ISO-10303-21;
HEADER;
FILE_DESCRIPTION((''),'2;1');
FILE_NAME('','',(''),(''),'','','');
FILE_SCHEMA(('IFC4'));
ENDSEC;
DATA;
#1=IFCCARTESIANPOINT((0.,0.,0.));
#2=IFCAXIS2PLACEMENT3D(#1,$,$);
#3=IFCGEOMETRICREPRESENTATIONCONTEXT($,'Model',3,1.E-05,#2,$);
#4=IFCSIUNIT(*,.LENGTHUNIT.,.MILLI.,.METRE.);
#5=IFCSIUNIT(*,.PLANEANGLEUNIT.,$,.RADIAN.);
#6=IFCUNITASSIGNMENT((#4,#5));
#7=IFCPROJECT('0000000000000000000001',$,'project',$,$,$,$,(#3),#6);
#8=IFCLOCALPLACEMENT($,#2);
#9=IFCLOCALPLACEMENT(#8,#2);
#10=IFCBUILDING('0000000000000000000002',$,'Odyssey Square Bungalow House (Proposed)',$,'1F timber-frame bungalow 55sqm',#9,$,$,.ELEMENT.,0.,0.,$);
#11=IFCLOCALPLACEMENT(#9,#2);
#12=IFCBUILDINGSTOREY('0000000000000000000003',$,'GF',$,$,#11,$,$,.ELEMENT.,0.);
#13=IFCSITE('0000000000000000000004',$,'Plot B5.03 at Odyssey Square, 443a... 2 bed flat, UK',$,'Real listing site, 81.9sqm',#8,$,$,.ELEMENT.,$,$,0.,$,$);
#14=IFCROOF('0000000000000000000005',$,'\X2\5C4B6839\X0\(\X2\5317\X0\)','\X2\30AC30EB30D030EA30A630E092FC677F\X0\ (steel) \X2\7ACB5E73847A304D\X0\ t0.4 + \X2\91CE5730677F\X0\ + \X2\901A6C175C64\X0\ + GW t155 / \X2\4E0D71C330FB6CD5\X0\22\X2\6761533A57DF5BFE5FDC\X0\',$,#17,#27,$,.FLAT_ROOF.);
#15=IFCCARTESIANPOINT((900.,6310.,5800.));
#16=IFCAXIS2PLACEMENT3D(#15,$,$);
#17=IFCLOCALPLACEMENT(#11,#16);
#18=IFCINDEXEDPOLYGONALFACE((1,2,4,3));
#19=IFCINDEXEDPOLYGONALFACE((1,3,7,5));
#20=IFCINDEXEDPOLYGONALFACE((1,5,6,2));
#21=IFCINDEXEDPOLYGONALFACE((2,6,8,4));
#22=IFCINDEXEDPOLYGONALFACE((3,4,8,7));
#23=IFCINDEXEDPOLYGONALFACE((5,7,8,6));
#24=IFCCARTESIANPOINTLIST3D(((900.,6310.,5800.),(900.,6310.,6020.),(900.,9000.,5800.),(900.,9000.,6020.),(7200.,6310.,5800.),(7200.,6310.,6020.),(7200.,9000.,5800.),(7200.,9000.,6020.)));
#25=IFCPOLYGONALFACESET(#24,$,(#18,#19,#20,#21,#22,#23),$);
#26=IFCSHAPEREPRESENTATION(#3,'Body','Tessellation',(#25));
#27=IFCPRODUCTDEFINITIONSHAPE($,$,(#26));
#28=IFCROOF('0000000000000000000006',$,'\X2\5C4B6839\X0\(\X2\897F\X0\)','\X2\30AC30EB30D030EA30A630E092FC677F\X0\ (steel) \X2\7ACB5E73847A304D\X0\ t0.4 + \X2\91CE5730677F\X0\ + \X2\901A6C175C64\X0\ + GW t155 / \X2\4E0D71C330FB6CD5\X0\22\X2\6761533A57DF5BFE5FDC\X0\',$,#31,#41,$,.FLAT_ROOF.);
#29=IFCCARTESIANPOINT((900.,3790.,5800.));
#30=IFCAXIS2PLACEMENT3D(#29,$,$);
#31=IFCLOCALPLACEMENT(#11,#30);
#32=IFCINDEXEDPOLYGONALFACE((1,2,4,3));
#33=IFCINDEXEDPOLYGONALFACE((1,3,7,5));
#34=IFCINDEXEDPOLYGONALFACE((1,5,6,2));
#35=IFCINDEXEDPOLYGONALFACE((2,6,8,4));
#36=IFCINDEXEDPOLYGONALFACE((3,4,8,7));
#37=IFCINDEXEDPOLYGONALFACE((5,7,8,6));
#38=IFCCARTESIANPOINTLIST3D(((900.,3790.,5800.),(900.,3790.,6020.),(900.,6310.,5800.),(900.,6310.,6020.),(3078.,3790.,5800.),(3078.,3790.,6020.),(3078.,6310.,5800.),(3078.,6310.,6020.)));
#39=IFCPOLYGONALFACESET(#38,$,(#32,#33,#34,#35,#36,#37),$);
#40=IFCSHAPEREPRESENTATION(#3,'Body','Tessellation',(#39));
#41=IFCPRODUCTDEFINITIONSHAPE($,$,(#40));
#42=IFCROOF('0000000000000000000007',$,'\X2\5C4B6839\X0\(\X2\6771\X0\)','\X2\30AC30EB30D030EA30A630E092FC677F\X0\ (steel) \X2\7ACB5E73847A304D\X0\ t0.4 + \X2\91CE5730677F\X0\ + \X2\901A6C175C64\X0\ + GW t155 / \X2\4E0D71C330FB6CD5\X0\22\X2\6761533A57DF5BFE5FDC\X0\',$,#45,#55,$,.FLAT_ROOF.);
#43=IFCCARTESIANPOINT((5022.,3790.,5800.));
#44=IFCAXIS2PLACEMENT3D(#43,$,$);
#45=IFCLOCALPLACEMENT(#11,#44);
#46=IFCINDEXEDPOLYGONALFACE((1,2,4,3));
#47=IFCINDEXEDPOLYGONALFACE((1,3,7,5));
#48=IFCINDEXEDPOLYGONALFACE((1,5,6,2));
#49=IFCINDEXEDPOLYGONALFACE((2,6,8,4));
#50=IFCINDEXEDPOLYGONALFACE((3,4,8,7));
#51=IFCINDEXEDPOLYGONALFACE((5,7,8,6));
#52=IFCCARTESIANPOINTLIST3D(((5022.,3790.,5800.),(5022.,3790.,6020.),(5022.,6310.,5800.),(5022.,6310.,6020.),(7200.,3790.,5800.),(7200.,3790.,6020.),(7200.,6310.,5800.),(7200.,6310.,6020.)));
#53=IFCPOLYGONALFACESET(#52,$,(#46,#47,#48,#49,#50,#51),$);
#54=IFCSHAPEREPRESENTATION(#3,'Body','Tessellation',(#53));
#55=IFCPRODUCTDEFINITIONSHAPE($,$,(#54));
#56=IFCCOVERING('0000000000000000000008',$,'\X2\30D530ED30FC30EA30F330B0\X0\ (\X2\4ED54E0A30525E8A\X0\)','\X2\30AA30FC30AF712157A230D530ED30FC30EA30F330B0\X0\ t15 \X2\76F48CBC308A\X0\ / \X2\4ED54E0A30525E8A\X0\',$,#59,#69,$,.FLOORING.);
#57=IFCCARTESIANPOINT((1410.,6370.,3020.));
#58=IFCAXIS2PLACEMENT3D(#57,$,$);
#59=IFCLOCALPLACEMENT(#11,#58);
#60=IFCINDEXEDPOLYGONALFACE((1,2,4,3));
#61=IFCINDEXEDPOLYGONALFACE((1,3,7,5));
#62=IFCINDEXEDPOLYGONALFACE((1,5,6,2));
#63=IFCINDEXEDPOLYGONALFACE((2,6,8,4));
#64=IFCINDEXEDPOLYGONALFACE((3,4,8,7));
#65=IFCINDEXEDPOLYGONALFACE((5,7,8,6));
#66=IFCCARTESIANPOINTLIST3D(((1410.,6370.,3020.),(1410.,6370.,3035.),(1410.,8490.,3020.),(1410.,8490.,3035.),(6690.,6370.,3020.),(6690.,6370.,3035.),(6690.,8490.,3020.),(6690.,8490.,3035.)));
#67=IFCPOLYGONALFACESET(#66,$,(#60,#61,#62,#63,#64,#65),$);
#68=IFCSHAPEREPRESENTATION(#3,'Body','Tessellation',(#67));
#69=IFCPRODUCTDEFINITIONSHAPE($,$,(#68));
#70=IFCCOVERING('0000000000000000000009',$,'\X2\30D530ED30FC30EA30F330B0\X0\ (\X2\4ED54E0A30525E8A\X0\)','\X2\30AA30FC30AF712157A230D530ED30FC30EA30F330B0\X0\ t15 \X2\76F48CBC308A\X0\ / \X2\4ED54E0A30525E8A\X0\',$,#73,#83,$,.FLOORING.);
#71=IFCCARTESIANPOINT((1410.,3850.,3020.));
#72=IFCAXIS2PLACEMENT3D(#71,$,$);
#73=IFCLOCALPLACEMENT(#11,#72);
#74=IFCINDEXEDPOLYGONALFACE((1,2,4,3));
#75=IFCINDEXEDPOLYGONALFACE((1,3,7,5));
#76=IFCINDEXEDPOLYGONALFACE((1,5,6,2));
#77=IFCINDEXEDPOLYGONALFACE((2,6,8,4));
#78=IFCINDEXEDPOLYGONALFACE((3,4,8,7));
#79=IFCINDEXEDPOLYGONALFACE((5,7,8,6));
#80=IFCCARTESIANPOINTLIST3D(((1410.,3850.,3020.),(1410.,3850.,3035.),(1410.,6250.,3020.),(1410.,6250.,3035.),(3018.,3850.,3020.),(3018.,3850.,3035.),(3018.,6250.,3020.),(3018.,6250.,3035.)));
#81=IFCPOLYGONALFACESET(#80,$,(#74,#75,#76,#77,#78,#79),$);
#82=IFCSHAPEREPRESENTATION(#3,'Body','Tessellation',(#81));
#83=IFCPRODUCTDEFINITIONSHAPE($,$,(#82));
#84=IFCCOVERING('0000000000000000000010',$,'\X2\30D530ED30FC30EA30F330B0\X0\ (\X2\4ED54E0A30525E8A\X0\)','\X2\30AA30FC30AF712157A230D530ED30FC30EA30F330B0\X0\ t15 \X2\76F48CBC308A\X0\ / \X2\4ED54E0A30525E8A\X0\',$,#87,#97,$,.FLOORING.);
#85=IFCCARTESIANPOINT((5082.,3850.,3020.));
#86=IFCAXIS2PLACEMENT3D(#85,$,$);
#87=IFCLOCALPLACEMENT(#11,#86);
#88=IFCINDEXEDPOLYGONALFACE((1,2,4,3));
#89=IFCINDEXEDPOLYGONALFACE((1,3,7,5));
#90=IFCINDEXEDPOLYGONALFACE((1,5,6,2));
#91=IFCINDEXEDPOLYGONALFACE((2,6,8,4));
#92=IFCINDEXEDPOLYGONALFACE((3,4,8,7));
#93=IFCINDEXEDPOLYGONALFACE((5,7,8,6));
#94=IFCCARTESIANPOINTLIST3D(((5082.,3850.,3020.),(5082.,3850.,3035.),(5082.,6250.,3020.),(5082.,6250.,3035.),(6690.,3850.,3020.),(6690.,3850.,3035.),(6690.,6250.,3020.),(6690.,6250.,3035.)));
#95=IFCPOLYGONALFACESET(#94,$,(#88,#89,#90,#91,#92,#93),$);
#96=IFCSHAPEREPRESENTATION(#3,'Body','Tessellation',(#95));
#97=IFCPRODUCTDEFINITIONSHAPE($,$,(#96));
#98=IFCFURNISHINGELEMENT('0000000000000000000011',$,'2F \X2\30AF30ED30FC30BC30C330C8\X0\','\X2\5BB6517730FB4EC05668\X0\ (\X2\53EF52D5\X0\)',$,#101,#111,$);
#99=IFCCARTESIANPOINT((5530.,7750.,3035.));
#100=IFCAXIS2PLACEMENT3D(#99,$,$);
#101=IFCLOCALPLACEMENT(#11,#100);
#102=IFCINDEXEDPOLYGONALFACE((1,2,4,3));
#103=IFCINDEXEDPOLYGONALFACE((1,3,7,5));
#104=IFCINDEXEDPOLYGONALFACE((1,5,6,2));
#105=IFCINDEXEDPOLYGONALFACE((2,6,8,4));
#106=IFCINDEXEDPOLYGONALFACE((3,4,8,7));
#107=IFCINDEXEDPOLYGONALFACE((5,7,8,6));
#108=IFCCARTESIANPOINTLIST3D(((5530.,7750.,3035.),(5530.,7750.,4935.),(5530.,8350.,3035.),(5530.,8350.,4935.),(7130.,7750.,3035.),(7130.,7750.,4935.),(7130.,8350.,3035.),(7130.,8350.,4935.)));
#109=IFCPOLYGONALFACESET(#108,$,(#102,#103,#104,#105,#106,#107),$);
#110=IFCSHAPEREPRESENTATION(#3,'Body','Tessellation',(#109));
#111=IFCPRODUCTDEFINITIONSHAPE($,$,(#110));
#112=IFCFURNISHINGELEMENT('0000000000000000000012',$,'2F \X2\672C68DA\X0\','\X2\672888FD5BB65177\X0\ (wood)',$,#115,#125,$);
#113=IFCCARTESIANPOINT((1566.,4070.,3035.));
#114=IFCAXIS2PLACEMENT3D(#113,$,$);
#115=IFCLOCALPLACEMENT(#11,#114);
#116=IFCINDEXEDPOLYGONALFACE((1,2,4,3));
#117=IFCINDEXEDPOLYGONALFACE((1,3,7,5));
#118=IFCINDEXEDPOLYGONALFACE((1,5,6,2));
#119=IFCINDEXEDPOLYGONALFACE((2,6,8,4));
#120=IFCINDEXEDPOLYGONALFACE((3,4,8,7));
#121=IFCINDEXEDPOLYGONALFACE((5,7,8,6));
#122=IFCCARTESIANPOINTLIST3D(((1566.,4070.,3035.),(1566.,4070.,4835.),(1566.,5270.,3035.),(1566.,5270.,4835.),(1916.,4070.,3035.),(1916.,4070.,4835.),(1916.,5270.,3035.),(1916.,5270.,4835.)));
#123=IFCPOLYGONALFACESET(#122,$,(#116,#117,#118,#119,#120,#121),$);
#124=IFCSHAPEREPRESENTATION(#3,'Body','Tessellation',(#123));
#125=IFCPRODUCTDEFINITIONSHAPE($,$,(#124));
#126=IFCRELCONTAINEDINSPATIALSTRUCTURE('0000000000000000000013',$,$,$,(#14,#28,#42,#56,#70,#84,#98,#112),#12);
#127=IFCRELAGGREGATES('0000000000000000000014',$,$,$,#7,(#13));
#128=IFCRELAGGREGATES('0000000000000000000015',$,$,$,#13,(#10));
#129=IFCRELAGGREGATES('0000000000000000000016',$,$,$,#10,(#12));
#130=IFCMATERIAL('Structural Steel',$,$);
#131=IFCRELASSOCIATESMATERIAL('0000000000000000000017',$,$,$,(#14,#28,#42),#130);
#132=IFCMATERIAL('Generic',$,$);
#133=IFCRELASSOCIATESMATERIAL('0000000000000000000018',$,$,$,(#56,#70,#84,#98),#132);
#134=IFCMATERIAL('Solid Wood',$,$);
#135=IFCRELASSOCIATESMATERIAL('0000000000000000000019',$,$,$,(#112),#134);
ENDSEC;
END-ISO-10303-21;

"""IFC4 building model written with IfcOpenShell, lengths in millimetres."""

from ifc_helpers import new_model, si_unit, frame, frame_2d, origin, place, context, project, spatial, rectangle, extrude, material, element, save


model = new_model("IFC4")

# Units and contexts
model_context = context("Model", 3, precision=1e-05, world=origin())
ifc_project = project(units=[si_unit("LENGTHUNIT", "METRE", prefix="MILLI"), si_unit("PLANEANGLEUNIT", "RADIAN")], contexts=[model_context])

# Site, building, storey
site_placement = place(None, origin())
site = spatial("IfcSite", under=ifc_project, at=site_placement, Name="Plot B5.03 at Odyssey Square, 443a... 2 bed flat, UK", ObjectType="Real listing site, 81.9sqm", CompositionType="ELEMENT", RefElevation=0.0)
building_placement = place(site_placement, origin())
building = spatial("IfcBuilding", under=site, at=building_placement, Name="Odyssey Square Bungalow House (Proposed)", ObjectType="1F timber-frame bungalow 55sqm", CompositionType="ELEMENT", ElevationOfRefHeight=0.0, ElevationOfTerrain=0.0)
storey_placement = place(building_placement, origin())
storey = spatial("IfcBuildingStorey", under=building, at=storey_placement, Name="GF", CompositionType="ELEMENT", Elevation=0.0)

# Shared definitions
ifc_material_1 = material(Name="Solid Wood")

# Shared definitions
ifc_material_2 = material(Name="Generic")

# Roofs
ifc_material_3 = material(Name="Structural Steel")
for number, where, name in (
    (1, (900.0, 6310.0, 5800.0), "屋根(北)"),
):
    element("IfcRoof", number, at=place(storey_placement, frame(where)), inside=storey, material=ifc_material_3, Name=name, Description="ガルバリウム鋼板 (steel) 立平葺き t0.4 + 野地板 + 通気層 + GW t155 / 不燃・法22条区域対応", PredefinedType="FLAT_ROOF", context=model_context, shape_type="SweptSolid", body=[
        extrude(rectangle(XDim=6300.0, YDim=2690.0, at=frame_2d((3150.0, 1345.0))), frame((900.0, 6310.0, 5800.0)), (0.0, 0.0, 1.0), 220.0),
    ])
roof_1_placement = place(storey_placement, frame((900.0, 3790.0, 5800.0)))
element("IfcRoof", 2, at=roof_1_placement, inside=storey, material=ifc_material_3, Name="屋根(西)", Description="ガルバリウム鋼板 (steel) 立平葺き t0.4 + 野地板 + 通気層 + GW t155 / 不燃・法22条区域対応", PredefinedType="FLAT_ROOF", context=model_context, shape_type="SweptSolid", body=[
    extrude(rectangle(XDim=2178.0, YDim=2520.0, at=frame_2d((1089.0, 1260.0))), frame((900.0, 3790.0, 5800.0)), (0.0, 0.0, 1.0), 220.0),
])
roof_2_placement = place(storey_placement, frame((5022.0, 3790.0, 5800.0)))
element("IfcRoof", 3, at=roof_2_placement, inside=storey, material=ifc_material_3, Name="屋根(東)", Description="ガルバリウム鋼板 (steel) 立平葺き t0.4 + 野地板 + 通気層 + GW t155 / 不燃・法22条区域対応", PredefinedType="FLAT_ROOF", context=model_context, shape_type="SweptSolid", body=[
    extrude(rectangle(XDim=2178.0, YDim=2520.0, at=frame_2d((1089.0, 1260.0))), frame((5022.0, 3790.0, 5800.0)), (0.0, 0.0, 1.0), 220.0),
])

# Coverings
covering_1_placement = place(storey_placement, frame((1410.0, 6370.0, 3020.0)))
element("IfcCovering", 4, at=covering_1_placement, inside=storey, material=ifc_material_2, Name="フローリング (仕上げ床)", Description="オーク無垢フローリング t15 直貼り / 仕上げ床", PredefinedType="FLOORING", context=model_context, shape_type="SweptSolid", body=[
    extrude(rectangle(XDim=5280.0, YDim=2120.0, at=frame_2d((2640.0, 1060.0))), frame((1410.0, 6370.0, 3020.0)), (0.0, 0.0, 1.0), 15.0),
])
covering_2_placement = place(storey_placement, frame((1410.0, 3850.0, 3020.0)))
element("IfcCovering", 5, at=covering_2_placement, inside=storey, material=ifc_material_2, Name="フローリング (仕上げ床)", Description="オーク無垢フローリング t15 直貼り / 仕上げ床", PredefinedType="FLOORING", context=model_context, shape_type="SweptSolid", body=[
    extrude(rectangle(XDim=1608.0, YDim=2400.0, at=frame_2d((804.0, 1200.0))), frame((1410.0, 3850.0, 3020.0)), (0.0, 0.0, 1.0), 15.0),
])
covering_3_placement = place(storey_placement, frame((5082.0, 3850.0, 3020.0)))
element("IfcCovering", 6, at=covering_3_placement, inside=storey, material=ifc_material_2, Name="フローリング (仕上げ床)", Description="オーク無垢フローリング t15 直貼り / 仕上げ床", PredefinedType="FLOORING", context=model_context, shape_type="SweptSolid", body=[
    extrude(rectangle(XDim=1608.0, YDim=2400.0, at=frame_2d((804.0, 1200.0))), frame((5082.0, 3850.0, 3020.0)), (0.0, 0.0, 1.0), 15.0),
])

# Furnishing elements
furnishing_1_placement = place(storey_placement, frame((5530.0, 7750.0, 3035.0)))
element("IfcFurnishingElement", 7, at=furnishing_1_placement, inside=storey, material=ifc_material_2, Name="2F クローゼット", Description="家具・什器 (可動)", context=model_context, shape_type="SweptSolid", body=[
    extrude(rectangle(XDim=1600.0, YDim=600.0, at=frame_2d((800.0, 300.0))), frame((5530.0, 7750.0, 3035.0)), (0.0, 0.0, 1.0), 1900.0),
])
furnishing_2_placement = place(storey_placement, frame((1566.0, 4070.0, 3035.0)))
element("IfcFurnishingElement", 8, at=furnishing_2_placement, inside=storey, material=ifc_material_1, Name="2F 本棚", Description="木製家具 (wood)", context=model_context, shape_type="SweptSolid", body=[
    extrude(rectangle(XDim=350.0, YDim=1200.0, at=frame_2d((175.0, 600.0))), frame((1566.0, 4070.0, 3035.0)), (0.0, 0.0, 1.0), 1800.0),
])

save(model, "model.ifc")
